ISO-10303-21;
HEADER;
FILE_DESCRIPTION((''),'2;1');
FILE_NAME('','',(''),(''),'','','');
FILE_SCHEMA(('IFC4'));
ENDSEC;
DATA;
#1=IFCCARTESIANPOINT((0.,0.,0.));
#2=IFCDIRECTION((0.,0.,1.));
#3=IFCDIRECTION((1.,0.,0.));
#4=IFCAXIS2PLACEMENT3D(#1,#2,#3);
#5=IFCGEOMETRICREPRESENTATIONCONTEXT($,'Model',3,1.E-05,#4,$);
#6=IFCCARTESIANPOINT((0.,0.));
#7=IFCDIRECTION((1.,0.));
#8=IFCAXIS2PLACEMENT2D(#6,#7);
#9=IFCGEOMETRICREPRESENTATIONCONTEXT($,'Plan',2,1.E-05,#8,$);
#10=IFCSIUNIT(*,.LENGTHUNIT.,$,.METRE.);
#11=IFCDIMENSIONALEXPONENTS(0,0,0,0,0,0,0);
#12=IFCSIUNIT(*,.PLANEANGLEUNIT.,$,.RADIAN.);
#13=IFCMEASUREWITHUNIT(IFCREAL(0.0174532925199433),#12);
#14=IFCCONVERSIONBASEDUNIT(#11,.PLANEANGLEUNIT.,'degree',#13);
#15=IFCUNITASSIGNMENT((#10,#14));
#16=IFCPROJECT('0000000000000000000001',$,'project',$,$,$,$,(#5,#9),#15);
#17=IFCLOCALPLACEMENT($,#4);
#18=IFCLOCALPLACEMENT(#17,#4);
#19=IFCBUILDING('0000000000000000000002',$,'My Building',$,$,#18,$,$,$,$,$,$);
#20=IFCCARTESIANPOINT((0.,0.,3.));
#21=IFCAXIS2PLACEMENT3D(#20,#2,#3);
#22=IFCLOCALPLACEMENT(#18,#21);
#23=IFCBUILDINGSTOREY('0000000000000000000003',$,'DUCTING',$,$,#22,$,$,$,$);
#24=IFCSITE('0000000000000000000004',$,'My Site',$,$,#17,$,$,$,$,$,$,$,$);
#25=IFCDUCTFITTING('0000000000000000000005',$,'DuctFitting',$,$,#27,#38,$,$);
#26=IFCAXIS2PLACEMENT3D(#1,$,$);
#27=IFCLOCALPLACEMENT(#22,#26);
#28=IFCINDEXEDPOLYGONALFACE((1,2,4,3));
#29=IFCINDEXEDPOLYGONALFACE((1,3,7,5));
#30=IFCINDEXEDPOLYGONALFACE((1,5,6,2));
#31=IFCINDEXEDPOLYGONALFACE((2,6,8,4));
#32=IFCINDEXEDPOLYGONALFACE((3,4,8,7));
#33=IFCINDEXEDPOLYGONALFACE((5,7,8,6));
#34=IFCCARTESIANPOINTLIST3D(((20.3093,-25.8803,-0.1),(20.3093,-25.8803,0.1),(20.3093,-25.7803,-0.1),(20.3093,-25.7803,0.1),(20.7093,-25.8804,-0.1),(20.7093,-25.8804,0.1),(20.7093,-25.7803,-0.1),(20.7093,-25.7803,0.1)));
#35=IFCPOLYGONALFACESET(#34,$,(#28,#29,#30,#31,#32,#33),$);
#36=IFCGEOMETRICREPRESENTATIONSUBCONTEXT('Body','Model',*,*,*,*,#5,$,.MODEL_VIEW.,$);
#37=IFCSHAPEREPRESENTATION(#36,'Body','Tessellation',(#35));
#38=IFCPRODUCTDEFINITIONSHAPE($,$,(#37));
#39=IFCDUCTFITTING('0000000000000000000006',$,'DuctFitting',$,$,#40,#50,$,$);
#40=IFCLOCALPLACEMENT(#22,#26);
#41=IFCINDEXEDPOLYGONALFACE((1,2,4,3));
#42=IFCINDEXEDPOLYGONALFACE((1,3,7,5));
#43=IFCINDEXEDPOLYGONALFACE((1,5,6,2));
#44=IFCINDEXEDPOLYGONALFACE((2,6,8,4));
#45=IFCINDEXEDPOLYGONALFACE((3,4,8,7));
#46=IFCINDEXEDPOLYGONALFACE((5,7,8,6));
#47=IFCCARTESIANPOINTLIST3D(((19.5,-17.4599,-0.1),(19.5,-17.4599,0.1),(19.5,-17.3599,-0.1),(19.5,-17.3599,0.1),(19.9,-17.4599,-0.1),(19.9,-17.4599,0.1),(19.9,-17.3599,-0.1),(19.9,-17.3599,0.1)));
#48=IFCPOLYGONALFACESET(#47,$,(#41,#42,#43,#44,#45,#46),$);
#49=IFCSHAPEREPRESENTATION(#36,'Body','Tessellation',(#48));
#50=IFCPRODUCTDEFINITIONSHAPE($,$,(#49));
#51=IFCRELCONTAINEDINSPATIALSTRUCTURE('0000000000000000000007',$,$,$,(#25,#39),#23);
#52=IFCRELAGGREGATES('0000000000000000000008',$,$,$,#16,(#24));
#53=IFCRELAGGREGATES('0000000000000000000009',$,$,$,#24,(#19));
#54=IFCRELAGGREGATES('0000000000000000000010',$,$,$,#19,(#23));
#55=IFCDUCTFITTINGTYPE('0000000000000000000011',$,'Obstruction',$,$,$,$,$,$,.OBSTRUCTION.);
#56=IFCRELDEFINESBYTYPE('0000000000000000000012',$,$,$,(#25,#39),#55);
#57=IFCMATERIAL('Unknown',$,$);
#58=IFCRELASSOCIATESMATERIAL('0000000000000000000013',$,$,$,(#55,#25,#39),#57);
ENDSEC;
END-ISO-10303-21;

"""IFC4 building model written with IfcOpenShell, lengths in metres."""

from ifc_helpers import new_model, entity, si_unit, converted_unit, frame, origin_with_axes, origin_2d_with_axis, place, context, subcontext, project, spatial, rectangle, extrude, material, material_profile, profile_set, profile_usage, type_object, element, save


model = new_model("IFC4")

# Units and contexts
model_context = context("Model", 3, precision=1e-05, world=origin_with_axes())
plan_context = context("Plan", 2, precision=1e-05, world=origin_2d_with_axis())
body_context = subcontext(model_context, "Body", "Model", "MODEL_VIEW")
ifc_project = project(units=[si_unit("LENGTHUNIT", "METRE"), converted_unit("PLANEANGLEUNIT", "degree", entity("IfcReal", 0.0174532925199433), si_unit("PLANEANGLEUNIT", "RADIAN"), dimensions=[0, 0, 0, 0, 0, 0, 0])], contexts=[model_context, plan_context])

# Site, building, storey
site_placement = place(None, origin_with_axes())
site = spatial("IfcSite", under=ifc_project, at=site_placement, Name="My Site")
building_placement = place(site_placement, origin_with_axes())
building = spatial("IfcBuilding", under=site, at=building_placement, Name="My Building")
storey_placement = place(building_placement, frame((0.0, 0.0, 3.0), z_axis=(0.0, 0.0, 1.0), x_axis=(1.0, 0.0, 0.0)))
storey = spatial("IfcBuildingStorey", under=building, at=storey_placement, Name="DUCTING")

# Shared definitions
ifc_material = material(Name="Unknown")

# Duct fittings
ifc_material_profile_1 = material_profile(ifc_material, rectangle(XDim=0.4, YDim=0.2))
ifc_profile_set_1 = profile_set([ifc_material_profile_1])
duct_fitting_type_1 = type_object("IfcDuctFittingType", Name="Obstruction", PredefinedType="OBSTRUCTION", material=ifc_profile_set_1)
ifc_profile_usage_1 = profile_usage(ifc_profile_set_1, cardinal=5)
duct_fitting_1_placement = place(storey_placement, frame((20.5093, -25.8804, 0.0), z_axis=(0.000001, 1.0, 0.0), x_axis=(-1.0, 0.000001, 0.0)))
element("IfcDuctFitting", 1, at=duct_fitting_1_placement, inside=storey, type_object=duct_fitting_type_1, material=ifc_profile_usage_1, Name="DuctFitting", context=body_context, shape_type="SweptSolid", body=[
    extrude(rectangle(XDim=0.4, YDim=0.2), origin_with_axes(), (0.0, 0.0, 1.0), 0.1),
])
ifc_profile_usage_2 = profile_usage(ifc_profile_set_1, cardinal=5)
duct_fitting_2_placement = place(storey_placement, frame((19.7, -17.4599, 0.0), z_axis=(0.000001, 1.0, 0.0), x_axis=(-1.0, 0.000001, 0.0)))
element("IfcDuctFitting", 2, at=duct_fitting_2_placement, inside=storey, type_object=duct_fitting_type_1, material=ifc_profile_usage_2, Name="DuctFitting", context=body_context, shape_type="SweptSolid", body=[
    extrude(rectangle(XDim=0.4, YDim=0.2), origin_with_axes(), (0.0, 0.0, 1.0), 0.1),
])

save(model, "model.ifc")
